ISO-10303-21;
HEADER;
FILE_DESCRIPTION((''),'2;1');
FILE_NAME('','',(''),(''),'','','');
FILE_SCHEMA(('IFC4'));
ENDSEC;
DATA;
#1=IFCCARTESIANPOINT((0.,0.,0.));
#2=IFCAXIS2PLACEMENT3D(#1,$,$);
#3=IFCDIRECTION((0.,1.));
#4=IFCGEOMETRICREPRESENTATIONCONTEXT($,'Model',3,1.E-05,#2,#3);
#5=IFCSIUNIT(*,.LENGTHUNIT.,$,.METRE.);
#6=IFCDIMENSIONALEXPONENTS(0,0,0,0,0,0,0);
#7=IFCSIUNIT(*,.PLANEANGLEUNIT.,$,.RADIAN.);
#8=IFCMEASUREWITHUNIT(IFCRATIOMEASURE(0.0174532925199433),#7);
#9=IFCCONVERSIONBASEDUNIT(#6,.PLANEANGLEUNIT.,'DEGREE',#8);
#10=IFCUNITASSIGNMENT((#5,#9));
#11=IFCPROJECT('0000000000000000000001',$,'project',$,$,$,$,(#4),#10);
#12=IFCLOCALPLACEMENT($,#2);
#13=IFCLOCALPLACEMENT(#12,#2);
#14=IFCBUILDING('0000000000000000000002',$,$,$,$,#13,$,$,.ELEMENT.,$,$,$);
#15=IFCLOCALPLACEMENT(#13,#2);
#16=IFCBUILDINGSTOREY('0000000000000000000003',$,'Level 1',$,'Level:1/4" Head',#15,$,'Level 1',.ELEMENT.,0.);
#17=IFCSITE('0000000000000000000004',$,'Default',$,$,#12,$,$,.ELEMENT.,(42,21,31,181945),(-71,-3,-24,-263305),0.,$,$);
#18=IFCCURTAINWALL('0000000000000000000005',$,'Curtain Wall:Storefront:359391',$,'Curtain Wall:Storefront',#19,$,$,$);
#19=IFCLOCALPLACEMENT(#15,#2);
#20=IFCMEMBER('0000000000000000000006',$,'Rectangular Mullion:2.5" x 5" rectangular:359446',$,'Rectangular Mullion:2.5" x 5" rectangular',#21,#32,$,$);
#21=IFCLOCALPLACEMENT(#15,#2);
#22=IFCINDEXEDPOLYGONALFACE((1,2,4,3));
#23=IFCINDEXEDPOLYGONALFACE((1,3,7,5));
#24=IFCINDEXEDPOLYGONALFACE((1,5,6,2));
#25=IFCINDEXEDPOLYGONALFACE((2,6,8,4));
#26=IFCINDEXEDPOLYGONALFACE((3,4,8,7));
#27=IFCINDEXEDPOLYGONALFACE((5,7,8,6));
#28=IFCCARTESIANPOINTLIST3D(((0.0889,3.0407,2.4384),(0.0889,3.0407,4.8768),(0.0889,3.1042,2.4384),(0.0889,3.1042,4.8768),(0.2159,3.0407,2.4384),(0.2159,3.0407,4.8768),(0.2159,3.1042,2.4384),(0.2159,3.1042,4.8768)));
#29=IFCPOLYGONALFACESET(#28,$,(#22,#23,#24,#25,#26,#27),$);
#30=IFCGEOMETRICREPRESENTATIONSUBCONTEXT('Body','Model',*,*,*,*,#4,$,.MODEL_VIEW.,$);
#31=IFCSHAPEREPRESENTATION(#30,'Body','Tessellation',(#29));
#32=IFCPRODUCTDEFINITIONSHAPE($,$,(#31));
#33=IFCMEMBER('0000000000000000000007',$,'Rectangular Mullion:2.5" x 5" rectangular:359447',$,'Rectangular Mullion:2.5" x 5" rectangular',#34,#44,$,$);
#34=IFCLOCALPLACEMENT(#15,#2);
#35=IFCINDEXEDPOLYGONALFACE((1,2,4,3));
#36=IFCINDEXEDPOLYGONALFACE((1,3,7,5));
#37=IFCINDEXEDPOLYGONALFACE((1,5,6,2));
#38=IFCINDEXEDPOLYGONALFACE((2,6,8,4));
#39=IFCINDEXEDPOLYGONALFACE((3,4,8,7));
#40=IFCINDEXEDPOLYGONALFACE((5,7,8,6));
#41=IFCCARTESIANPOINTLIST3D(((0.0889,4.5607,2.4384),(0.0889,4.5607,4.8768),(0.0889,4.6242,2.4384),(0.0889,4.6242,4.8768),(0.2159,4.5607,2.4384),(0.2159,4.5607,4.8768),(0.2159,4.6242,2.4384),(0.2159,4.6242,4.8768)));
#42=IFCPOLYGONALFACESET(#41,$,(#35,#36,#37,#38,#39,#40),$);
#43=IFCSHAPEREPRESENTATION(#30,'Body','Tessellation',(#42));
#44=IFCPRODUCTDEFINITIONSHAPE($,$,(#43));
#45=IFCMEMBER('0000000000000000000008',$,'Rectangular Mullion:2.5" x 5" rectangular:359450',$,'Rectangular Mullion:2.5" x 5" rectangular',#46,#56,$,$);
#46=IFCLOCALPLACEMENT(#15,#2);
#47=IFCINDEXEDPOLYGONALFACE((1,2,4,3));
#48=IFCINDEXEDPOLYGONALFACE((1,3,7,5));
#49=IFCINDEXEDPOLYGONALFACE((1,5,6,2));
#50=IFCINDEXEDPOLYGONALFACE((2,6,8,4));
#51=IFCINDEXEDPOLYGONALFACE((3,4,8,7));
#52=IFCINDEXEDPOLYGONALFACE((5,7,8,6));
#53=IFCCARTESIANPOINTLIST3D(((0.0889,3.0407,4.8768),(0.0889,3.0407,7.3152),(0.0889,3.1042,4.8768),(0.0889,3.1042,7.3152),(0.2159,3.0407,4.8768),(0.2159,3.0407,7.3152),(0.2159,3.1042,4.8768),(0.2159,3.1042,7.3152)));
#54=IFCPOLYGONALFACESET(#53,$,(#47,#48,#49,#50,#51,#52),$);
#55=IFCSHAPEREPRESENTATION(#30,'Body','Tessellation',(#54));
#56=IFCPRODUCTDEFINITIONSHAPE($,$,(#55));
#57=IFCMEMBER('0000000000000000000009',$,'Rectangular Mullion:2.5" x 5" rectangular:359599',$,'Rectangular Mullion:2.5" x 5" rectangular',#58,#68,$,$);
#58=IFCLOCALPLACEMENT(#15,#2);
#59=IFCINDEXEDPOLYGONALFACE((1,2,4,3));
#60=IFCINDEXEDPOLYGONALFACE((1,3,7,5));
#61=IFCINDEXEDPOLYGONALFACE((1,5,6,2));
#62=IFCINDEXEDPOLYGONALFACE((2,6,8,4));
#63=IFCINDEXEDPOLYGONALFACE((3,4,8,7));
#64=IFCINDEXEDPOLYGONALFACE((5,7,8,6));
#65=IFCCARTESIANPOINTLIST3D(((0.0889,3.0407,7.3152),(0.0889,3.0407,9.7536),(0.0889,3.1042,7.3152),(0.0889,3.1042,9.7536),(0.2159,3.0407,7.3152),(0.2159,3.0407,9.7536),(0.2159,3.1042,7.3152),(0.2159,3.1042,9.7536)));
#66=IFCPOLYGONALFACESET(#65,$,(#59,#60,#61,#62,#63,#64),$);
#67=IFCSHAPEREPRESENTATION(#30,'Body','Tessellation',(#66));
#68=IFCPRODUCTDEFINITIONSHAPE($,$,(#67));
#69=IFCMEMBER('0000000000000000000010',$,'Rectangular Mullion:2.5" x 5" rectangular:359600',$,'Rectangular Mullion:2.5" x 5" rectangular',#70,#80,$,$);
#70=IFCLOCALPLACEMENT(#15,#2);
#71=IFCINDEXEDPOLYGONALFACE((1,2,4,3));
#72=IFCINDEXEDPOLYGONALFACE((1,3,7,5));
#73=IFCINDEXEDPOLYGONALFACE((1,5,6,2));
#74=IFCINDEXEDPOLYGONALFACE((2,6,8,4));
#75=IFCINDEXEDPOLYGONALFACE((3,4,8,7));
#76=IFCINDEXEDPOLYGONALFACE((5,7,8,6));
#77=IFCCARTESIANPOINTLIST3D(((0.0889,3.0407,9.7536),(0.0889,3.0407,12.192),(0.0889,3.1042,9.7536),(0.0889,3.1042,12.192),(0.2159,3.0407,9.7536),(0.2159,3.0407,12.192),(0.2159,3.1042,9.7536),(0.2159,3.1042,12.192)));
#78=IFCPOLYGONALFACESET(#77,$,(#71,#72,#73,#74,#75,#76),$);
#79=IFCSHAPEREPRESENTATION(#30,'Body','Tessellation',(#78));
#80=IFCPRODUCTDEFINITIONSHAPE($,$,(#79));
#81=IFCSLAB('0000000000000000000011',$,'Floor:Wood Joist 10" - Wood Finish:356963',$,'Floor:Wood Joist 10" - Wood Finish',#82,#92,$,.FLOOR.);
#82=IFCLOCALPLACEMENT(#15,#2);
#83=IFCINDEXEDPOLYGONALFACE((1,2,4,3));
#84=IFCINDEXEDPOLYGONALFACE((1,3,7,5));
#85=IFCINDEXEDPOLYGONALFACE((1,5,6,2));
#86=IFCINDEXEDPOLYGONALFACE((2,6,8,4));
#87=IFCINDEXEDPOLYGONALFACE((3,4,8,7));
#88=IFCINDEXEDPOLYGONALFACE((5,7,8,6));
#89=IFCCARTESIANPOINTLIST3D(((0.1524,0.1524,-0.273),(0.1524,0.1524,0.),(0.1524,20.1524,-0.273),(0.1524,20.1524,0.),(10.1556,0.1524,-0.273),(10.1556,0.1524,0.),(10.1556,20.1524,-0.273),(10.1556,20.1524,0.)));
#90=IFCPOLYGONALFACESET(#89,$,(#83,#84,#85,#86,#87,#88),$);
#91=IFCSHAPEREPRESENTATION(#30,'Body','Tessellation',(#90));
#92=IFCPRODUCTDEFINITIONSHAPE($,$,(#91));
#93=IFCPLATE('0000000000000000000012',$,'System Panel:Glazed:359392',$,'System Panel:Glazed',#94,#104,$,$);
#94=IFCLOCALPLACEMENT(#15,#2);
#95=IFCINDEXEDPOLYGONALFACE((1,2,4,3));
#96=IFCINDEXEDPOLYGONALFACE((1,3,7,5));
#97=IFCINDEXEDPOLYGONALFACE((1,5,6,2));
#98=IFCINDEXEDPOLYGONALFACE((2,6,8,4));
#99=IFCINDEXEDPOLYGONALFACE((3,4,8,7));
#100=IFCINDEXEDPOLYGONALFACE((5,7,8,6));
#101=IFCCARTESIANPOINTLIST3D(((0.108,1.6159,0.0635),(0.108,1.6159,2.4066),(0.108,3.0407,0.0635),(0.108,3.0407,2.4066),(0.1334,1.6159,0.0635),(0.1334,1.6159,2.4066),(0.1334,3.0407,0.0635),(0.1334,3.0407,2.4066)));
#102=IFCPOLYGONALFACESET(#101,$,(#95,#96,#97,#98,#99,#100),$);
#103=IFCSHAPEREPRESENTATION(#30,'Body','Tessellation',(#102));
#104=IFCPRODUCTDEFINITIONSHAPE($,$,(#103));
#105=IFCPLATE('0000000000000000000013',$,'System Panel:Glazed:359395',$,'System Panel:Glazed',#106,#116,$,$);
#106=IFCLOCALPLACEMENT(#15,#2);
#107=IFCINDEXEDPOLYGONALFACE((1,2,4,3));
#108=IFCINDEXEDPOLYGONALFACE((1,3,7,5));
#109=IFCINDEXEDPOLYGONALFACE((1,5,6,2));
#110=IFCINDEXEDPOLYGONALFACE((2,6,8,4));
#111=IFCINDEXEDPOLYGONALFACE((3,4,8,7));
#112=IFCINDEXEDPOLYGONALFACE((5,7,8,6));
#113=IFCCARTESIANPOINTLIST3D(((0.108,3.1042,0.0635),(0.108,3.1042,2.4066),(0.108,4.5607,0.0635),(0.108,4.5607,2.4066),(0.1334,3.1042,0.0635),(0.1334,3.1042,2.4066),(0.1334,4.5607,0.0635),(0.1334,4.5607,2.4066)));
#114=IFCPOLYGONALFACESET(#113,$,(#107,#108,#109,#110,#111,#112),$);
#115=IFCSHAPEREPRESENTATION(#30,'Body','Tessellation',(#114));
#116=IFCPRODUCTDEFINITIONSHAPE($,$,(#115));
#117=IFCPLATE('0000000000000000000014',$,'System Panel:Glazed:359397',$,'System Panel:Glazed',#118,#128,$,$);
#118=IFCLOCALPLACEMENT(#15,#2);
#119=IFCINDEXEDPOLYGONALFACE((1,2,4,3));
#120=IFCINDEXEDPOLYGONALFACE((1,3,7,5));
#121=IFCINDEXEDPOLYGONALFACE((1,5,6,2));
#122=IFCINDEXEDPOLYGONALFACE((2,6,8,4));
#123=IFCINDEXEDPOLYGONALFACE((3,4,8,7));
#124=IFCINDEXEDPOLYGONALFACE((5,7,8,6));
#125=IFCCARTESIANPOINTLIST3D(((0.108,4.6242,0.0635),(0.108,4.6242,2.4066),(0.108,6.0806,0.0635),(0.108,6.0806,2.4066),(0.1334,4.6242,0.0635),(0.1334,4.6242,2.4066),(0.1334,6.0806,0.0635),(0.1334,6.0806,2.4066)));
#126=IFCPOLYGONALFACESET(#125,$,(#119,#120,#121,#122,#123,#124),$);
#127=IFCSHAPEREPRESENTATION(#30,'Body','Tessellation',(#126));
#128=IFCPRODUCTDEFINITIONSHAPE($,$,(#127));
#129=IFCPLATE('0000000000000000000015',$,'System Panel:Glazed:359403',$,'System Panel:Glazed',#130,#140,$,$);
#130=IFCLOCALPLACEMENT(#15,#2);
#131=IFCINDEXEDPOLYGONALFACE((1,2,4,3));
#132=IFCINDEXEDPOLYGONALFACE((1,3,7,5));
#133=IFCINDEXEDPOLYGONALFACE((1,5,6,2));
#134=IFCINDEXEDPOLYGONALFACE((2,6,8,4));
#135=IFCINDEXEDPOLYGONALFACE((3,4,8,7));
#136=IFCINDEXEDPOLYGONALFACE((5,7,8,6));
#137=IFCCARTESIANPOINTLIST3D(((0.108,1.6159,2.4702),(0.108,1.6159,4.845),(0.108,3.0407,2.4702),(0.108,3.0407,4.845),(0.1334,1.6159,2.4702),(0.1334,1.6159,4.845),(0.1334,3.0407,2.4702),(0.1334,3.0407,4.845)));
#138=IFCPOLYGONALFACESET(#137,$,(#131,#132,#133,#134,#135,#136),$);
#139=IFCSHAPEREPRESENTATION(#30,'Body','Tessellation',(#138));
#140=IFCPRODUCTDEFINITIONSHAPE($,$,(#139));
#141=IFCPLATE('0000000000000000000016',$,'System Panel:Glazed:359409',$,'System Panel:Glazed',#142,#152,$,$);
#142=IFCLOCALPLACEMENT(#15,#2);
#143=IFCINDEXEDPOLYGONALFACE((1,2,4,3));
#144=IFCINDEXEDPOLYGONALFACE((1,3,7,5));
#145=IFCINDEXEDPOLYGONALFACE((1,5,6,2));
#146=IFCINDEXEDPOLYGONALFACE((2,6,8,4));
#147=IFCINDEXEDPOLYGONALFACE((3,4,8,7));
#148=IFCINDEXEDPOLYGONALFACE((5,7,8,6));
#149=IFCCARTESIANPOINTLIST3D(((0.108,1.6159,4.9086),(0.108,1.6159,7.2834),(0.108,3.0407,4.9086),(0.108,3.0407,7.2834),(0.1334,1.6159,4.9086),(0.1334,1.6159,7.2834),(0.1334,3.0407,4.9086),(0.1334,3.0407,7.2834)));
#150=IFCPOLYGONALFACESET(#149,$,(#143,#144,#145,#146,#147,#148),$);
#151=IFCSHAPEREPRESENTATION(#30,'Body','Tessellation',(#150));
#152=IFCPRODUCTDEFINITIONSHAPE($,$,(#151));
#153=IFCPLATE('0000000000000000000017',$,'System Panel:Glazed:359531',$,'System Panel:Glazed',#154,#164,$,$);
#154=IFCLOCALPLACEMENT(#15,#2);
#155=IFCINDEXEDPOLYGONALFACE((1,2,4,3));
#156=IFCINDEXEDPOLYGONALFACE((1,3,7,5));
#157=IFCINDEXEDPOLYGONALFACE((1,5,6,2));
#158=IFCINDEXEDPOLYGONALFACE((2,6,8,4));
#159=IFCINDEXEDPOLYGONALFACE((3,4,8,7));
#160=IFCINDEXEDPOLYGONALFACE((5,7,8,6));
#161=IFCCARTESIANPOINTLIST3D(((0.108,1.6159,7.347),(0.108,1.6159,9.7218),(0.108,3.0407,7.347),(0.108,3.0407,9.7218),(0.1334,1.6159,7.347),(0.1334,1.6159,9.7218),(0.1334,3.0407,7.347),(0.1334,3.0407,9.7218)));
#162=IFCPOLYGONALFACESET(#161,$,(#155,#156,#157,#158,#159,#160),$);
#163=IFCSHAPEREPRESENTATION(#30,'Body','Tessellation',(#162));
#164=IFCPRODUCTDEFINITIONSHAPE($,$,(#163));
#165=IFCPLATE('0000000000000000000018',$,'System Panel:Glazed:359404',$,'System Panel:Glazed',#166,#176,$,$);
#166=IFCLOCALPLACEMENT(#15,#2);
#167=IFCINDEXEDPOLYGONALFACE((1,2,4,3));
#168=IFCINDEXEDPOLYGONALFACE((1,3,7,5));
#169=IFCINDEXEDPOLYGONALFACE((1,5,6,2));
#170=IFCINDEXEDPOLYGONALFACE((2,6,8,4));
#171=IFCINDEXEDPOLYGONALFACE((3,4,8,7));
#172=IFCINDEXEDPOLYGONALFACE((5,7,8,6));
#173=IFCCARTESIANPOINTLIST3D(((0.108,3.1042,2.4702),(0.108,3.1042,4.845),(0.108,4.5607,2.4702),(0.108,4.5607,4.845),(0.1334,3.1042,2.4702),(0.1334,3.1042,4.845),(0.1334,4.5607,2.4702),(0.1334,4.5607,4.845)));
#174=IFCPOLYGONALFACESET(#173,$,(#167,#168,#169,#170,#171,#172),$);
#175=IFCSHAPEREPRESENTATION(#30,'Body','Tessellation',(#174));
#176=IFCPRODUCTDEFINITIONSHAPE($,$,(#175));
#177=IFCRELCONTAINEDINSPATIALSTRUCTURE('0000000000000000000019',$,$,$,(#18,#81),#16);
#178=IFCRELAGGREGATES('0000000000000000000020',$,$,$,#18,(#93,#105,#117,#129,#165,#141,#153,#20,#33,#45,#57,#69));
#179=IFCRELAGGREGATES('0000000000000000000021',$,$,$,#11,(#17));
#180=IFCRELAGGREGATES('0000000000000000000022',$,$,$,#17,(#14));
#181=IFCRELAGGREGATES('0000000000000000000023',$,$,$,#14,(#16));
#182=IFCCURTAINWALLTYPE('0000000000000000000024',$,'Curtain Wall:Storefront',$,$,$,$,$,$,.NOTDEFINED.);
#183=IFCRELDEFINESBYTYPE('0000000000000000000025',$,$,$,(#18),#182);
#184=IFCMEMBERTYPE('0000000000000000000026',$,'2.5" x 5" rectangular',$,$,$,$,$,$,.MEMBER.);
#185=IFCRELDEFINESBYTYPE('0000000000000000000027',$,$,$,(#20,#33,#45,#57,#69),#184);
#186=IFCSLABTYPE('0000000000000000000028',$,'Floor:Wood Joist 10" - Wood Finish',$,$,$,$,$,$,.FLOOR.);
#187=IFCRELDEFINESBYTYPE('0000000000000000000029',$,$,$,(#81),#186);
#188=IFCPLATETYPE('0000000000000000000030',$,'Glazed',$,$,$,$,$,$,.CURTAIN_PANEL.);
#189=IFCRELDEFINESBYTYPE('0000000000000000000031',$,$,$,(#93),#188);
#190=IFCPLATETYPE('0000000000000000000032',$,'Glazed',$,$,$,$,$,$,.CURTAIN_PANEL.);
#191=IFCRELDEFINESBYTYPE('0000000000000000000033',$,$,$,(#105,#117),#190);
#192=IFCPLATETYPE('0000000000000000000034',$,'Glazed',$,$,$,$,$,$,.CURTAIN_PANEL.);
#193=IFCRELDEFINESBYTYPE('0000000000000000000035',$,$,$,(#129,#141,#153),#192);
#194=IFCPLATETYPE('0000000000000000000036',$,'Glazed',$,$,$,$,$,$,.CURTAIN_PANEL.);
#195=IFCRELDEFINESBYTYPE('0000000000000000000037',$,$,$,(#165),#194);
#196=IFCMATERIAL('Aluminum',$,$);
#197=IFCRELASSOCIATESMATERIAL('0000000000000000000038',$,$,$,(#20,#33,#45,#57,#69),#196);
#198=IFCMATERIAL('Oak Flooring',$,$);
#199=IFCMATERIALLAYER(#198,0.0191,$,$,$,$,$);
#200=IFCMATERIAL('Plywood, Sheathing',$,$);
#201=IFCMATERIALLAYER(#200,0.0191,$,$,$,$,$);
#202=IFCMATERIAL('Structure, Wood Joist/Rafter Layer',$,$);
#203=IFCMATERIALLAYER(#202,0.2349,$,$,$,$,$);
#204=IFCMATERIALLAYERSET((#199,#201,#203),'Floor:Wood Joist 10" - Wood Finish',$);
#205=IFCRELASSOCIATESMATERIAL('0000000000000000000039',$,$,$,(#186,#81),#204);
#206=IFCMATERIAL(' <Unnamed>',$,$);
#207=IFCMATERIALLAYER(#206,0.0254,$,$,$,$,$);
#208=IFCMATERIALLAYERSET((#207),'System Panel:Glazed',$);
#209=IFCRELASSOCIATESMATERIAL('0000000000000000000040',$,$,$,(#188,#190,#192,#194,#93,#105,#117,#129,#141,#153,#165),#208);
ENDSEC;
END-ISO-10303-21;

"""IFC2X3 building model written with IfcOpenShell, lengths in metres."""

from ifc_helpers import new_model, entity, si_unit, converted_unit, direction, frame, frame_2d, origin, origin_2d_with_axis, place, context, subcontext, project, spatial, rectangle, extrude, source, transform, mapped, material, layer, layer_set, layer_usage, type_object, type_shapes, element, aggregate, save


model = new_model("IFC2X3")

# Units and contexts
model_context = context("Model", 3, precision=1e-05, world=origin(), true_north=direction((0.0, 1.0)))
body_context = subcontext(model_context, "Body", "Model", "MODEL_VIEW")
ifc_project = project(units=[si_unit("LENGTHUNIT", "METRE"), converted_unit("PLANEANGLEUNIT", "DEGREE", entity("IfcRatioMeasure", 0.0174532925199433), si_unit("PLANEANGLEUNIT", "RADIAN"), dimensions=[0, 0, 0, 0, 0, 0, 0])], contexts=[model_context])

# Site, building, storey
site_placement = place(None, origin())
site = spatial("IfcSite", under=ifc_project, at=site_placement, Name="Default", CompositionType="ELEMENT", RefLatitude=(42, 21, 31, 181945), RefLongitude=(-71, -3, -24, -263305), RefElevation=0.0)
building_placement = place(site_placement, origin())
building = spatial("IfcBuilding", under=site, at=building_placement, CompositionType="ELEMENT")
storey_placement = place(building_placement, origin())
storey = spatial("IfcBuildingStorey", under=building, at=storey_placement, Name="Level 1", ObjectType="Level:1/4\" Head", LongName="Level 1", CompositionType="ELEMENT", Elevation=0.0)

# Curtain wall, members
curtain_wall_type = type_object("IfcCurtainWallType", Name="Curtain Wall:Storefront", PredefinedType="NOTDEFINED")
curtain_wall_placement = place(storey_placement, origin())
curtain_wall = element("IfcCurtainWall", 1, at=curtain_wall_placement, inside=storey, type_object=curtain_wall_type, Name="Curtain Wall:Storefront:359391", ObjectType="Curtain Wall:Storefront")
ifc_material_1 = material(Name="Aluminum")
member_type_1 = type_object("IfcMemberType", Name="2.5\" x 5\" rectangular", PredefinedType="MEMBER")
shared_shape_1 = source(origin(), body_context, "Body", "SweptSolid", [
    extrude(rectangle(XDim=0.127, YDim=0.0635, at=origin_2d_with_axis()), frame((0.0, 0.0, -2.4384), z_axis=(0.0, 0.0, 1.0), x_axis=(0.0, -1.0, 0.0)), (0.0, 0.0, 1.0), 2.4384),
])
type_shapes(member_type_1, [shared_shape_1])
member_1_placement = place(storey_placement, frame((0.1524, 3.0724, 2.4384), z_axis=(0.0, 0.0, -1.0), x_axis=(0.0, 1.0, 0.0)))
member_1 = element("IfcMember", 2, at=member_1_placement, type_object=member_type_1, material=ifc_material_1, Name="Rectangular Mullion:2.5\" x 5\" rectangular:359446", ObjectType="Rectangular Mullion:2.5\" x 5\" rectangular", context=body_context, shape_type="MappedRepresentation", body=[
    mapped(shared_shape_1, transform((0.0, 0.0, 0.0), scale=1.0)),
])
member_2_placement = place(storey_placement, frame((0.1524, 4.5924, 2.4384), z_axis=(0.0, 0.0, -1.0), x_axis=(0.0, 1.0, 0.0)))
member_2 = element("IfcMember", 3, at=member_2_placement, type_object=member_type_1, material=ifc_material_1, Name="Rectangular Mullion:2.5\" x 5\" rectangular:359447", ObjectType="Rectangular Mullion:2.5\" x 5\" rectangular", context=body_context, shape_type="MappedRepresentation", body=[
    mapped(shared_shape_1, transform((0.0, 0.0, 0.0), scale=1.0)),
])
member_3_placement = place(storey_placement, frame((0.1524, 3.0724, 4.8768), z_axis=(0.0, 0.0, -1.0), x_axis=(0.0, 1.0, 0.0)))
member_3 = element("IfcMember", 4, at=member_3_placement, type_object=member_type_1, material=ifc_material_1, Name="Rectangular Mullion:2.5\" x 5\" rectangular:359450", ObjectType="Rectangular Mullion:2.5\" x 5\" rectangular", context=body_context, shape_type="MappedRepresentation", body=[
    mapped(shared_shape_1, transform((0.0, 0.0, 0.0), scale=1.0)),
])
member_4_placement = place(storey_placement, frame((0.1524, 3.0724, 7.3152), z_axis=(0.0, 0.0, -1.0), x_axis=(0.0, 1.0, 0.0)))
member_4 = element("IfcMember", 5, at=member_4_placement, type_object=member_type_1, material=ifc_material_1, Name="Rectangular Mullion:2.5\" x 5\" rectangular:359599", ObjectType="Rectangular Mullion:2.5\" x 5\" rectangular", context=body_context, shape_type="MappedRepresentation", body=[
    mapped(shared_shape_1, transform((0.0, 0.0, 0.0), scale=1.0)),
])
member_5_placement = place(storey_placement, frame((0.1524, 3.0724, 9.7536), z_axis=(0.0, 0.0, -1.0), x_axis=(0.0, 1.0, 0.0)))
member_5 = element("IfcMember", 6, at=member_5_placement, type_object=member_type_1, material=ifc_material_1, Name="Rectangular Mullion:2.5\" x 5\" rectangular:359600", ObjectType="Rectangular Mullion:2.5\" x 5\" rectangular", context=body_context, shape_type="MappedRepresentation", body=[
    mapped(shared_shape_1, transform((0.0, 0.0, 0.0), scale=1.0)),
])

# Slab
ifc_material_2 = material(Name="Oak Flooring")
ifc_layer_1 = layer(ifc_material_2, 0.0191)
ifc_material_3 = material(Name="Plywood, Sheathing")
ifc_layer_2 = layer(ifc_material_3, 0.0191)
ifc_material_4 = material(Name="Structure, Wood Joist/Rafter Layer")
ifc_layer_3 = layer(ifc_material_4, 0.2349)
ifc_layer_set_1 = layer_set([ifc_layer_1, ifc_layer_2, ifc_layer_3], Name="Floor:Wood Joist 10\" - Wood Finish")
ifc_layer_usage_1 = layer_usage(ifc_layer_set_1, "AXIS3", "POSITIVE", 0.0)
slab_type_1 = type_object("IfcSlabType", Name="Floor:Wood Joist 10\" - Wood Finish", PredefinedType="FLOOR", material=ifc_layer_set_1)
slab_1_placement = place(storey_placement, origin())
element("IfcSlab", 7, at=slab_1_placement, inside=storey, type_object=slab_type_1, material=ifc_layer_usage_1, Name="Floor:Wood Joist 10\" - Wood Finish:356963", ObjectType="Floor:Wood Joist 10\" - Wood Finish", PredefinedType="FLOOR", context=body_context, shape_type="SweptSolid", body=[
    extrude(rectangle(XDim=20.0, YDim=10.0032, at=origin_2d_with_axis()), frame((5.154, 10.1524, 0.0), z_axis=(0.0, 0.0, -1.0), x_axis=(0.0, 1.0, 0.0)), (0.0, 0.0, 1.0), 0.2731),
])

# Plates
ifc_material_5 = material(Name=" <Unnamed>")
ifc_layer_4 = layer(ifc_material_5, 0.0254)
ifc_layer_set_2 = layer_set([ifc_layer_4], Name="System Panel:Glazed")
ifc_layer_usage_2 = layer_usage(ifc_layer_set_2, "AXIS3", "POSITIVE", 0.1042)
plate_type_1 = type_object("IfcPlateType", Name="Glazed", PredefinedType="CURTAIN_PANEL", material=ifc_layer_set_2)
shared_shape_2 = source(origin(), body_context, "Body", "SweptSolid", [
    extrude(rectangle(XDim=0.0254, YDim=1.4248, at=frame_2d((0.0, 0.0), x_axis=(1.0, 0.0))), frame((0.7124, 0.0127, 0.0), z_axis=(0.0, 0.0, 1.0), x_axis=(0.0, 1.0, 0.0)), (0.0, 0.0, 1.0), 2.3432),
])
type_shapes(plate_type_1, [shared_shape_2])
plate_1_placement = place(curtain_wall_placement, frame((0.1334, 1.6159, 0.0635), z_axis=(0.0, 0.0, 1.0), x_axis=(0.0, 1.0, 0.0)))
plate_1 = element("IfcPlate", 8, at=plate_1_placement, type_object=plate_type_1, material=ifc_layer_usage_2, Name="System Panel:Glazed:359392", ObjectType="System Panel:Glazed", context=body_context, shape_type="MappedRepresentation", body=[
    mapped(shared_shape_2, transform((0.0, 0.0, 0.0), scale=1.0)),
])
ifc_layer_usage_3 = layer_usage(ifc_layer_set_2, "AXIS3", "POSITIVE", 0.1042)
plate_type_2 = type_object("IfcPlateType", Name="Glazed", PredefinedType="CURTAIN_PANEL", material=ifc_layer_set_2)
shared_shape_3 = source(origin(), body_context, "Body", "SweptSolid", [
    extrude(rectangle(XDim=0.0254, YDim=1.4565, at=frame_2d((0.0, 0.0), x_axis=(1.0, 0.0))), frame((0.7282, 0.0127, 0.0), z_axis=(0.0, 0.0, 1.0), x_axis=(0.0, 1.0, 0.0)), (0.0, 0.0, 1.0), 2.3432),
])
type_shapes(plate_type_2, [shared_shape_3])
plate_2_placement = place(curtain_wall_placement, frame((0.1334, 3.1042, 0.0635), z_axis=(0.0, 0.0, 1.0), x_axis=(0.0, 1.0, 0.0)))
plate_2 = element("IfcPlate", 9, at=plate_2_placement, type_object=plate_type_2, material=ifc_layer_usage_3, Name="System Panel:Glazed:359395", ObjectType="System Panel:Glazed", context=body_context, shape_type="MappedRepresentation", body=[
    mapped(shared_shape_3, transform((0.0, 0.0, 0.0), scale=1.0)),
])
ifc_layer_usage_4 = layer_usage(ifc_layer_set_2, "AXIS3", "POSITIVE", 0.1042)
plate_3_placement = place(curtain_wall_placement, frame((0.1334, 4.6242, 0.0635), z_axis=(0.0, 0.0, 1.0), x_axis=(0.0, 1.0, 0.0)))
plate_3 = element("IfcPlate", 10, at=plate_3_placement, type_object=plate_type_2, material=ifc_layer_usage_4, Name="System Panel:Glazed:359397", ObjectType="System Panel:Glazed", context=body_context, shape_type="MappedRepresentation", body=[
    mapped(shared_shape_3, transform((0.0, 0.0, 0.0), scale=1.0)),
])
ifc_layer_usage_5 = layer_usage(ifc_layer_set_2, "AXIS3", "POSITIVE", 0.1042)
plate_type_3 = type_object("IfcPlateType", Name="Glazed", PredefinedType="CURTAIN_PANEL", material=ifc_layer_set_2)
shared_shape_4 = source(origin(), body_context, "Body", "SweptSolid", [
    extrude(rectangle(XDim=0.0254, YDim=1.4248, at=frame_2d((0.0, 0.0), x_axis=(1.0, 0.0))), frame((0.7124, 0.0127, 0.0), z_axis=(0.0, 0.0, 1.0), x_axis=(0.0, 1.0, 0.0)), (0.0, 0.0, 1.0), 2.3749),
])
type_shapes(plate_type_3, [shared_shape_4])
plate_4_placement = place(curtain_wall_placement, frame((0.1334, 1.6159, 2.4701), z_axis=(0.0, 0.0, 1.0), x_axis=(0.0, 1.0, 0.0)))
plate_4 = element("IfcPlate", 11, at=plate_4_placement, type_object=plate_type_3, material=ifc_layer_usage_5, Name="System Panel:Glazed:359403", ObjectType="System Panel:Glazed", context=body_context, shape_type="MappedRepresentation", body=[
    mapped(shared_shape_4, transform((0.0, 0.0, 0.0), scale=1.0)),
])
ifc_layer_usage_6 = layer_usage(ifc_layer_set_2, "AXIS3", "POSITIVE", 0.1042)
plate_5_placement = place(curtain_wall_placement, frame((0.1334, 1.6159, 4.9085), z_axis=(0.0, 0.0, 1.0), x_axis=(0.0, 1.0, 0.0)))
plate_5 = element("IfcPlate", 12, at=plate_5_placement, type_object=plate_type_3, material=ifc_layer_usage_6, Name="System Panel:Glazed:359409", ObjectType="System Panel:Glazed", context=body_context, shape_type="MappedRepresentation", body=[
    mapped(shared_shape_4, transform((0.0, 0.0, 0.0), scale=1.0)),
])
ifc_layer_usage_7 = layer_usage(ifc_layer_set_2, "AXIS3", "POSITIVE", 0.1042)
plate_6_placement = place(curtain_wall_placement, frame((0.1334, 1.6159, 7.3469), z_axis=(0.0, 0.0, 1.0), x_axis=(0.0, 1.0, 0.0)))
plate_6 = element("IfcPlate", 13, at=plate_6_placement, type_object=plate_type_3, material=ifc_layer_usage_7, Name="System Panel:Glazed:359531", ObjectType="System Panel:Glazed", context=body_context, shape_type="MappedRepresentation", body=[
    mapped(shared_shape_4, transform((0.0, 0.0, 0.0), scale=1.0)),
])
ifc_layer_usage_8 = layer_usage(ifc_layer_set_2, "AXIS3", "POSITIVE", 0.1042)
plate_type_4 = type_object("IfcPlateType", Name="Glazed", PredefinedType="CURTAIN_PANEL", material=ifc_layer_set_2)
shared_shape_5 = source(origin(), body_context, "Body", "SweptSolid", [
    extrude(rectangle(XDim=0.0254, YDim=1.4565, at=frame_2d((0.0, 0.0), x_axis=(1.0, 0.0))), frame((0.7282, 0.0127, 0.0), z_axis=(0.0, 0.0, 1.0), x_axis=(0.0, 1.0, 0.0)), (0.0, 0.0, 1.0), 2.3749),
])
type_shapes(plate_type_4, [shared_shape_5])
plate_7_placement = place(curtain_wall_placement, frame((0.1334, 3.1042, 2.4701), z_axis=(0.0, 0.0, 1.0), x_axis=(0.0, 1.0, 0.0)))
plate_7 = element("IfcPlate", 14, at=plate_7_placement, type_object=plate_type_4, material=ifc_layer_usage_8, Name="System Panel:Glazed:359404", ObjectType="System Panel:Glazed", context=body_context, shape_type="MappedRepresentation", body=[
    mapped(shared_shape_5, transform((0.0, 0.0, 0.0), scale=1.0)),
])
aggregate(curtain_wall, [plate_1, plate_2, plate_3, plate_4, plate_7, plate_5, plate_6, member_1, member_2, member_3, member_4, member_5])

save(model, "model.ifc")
